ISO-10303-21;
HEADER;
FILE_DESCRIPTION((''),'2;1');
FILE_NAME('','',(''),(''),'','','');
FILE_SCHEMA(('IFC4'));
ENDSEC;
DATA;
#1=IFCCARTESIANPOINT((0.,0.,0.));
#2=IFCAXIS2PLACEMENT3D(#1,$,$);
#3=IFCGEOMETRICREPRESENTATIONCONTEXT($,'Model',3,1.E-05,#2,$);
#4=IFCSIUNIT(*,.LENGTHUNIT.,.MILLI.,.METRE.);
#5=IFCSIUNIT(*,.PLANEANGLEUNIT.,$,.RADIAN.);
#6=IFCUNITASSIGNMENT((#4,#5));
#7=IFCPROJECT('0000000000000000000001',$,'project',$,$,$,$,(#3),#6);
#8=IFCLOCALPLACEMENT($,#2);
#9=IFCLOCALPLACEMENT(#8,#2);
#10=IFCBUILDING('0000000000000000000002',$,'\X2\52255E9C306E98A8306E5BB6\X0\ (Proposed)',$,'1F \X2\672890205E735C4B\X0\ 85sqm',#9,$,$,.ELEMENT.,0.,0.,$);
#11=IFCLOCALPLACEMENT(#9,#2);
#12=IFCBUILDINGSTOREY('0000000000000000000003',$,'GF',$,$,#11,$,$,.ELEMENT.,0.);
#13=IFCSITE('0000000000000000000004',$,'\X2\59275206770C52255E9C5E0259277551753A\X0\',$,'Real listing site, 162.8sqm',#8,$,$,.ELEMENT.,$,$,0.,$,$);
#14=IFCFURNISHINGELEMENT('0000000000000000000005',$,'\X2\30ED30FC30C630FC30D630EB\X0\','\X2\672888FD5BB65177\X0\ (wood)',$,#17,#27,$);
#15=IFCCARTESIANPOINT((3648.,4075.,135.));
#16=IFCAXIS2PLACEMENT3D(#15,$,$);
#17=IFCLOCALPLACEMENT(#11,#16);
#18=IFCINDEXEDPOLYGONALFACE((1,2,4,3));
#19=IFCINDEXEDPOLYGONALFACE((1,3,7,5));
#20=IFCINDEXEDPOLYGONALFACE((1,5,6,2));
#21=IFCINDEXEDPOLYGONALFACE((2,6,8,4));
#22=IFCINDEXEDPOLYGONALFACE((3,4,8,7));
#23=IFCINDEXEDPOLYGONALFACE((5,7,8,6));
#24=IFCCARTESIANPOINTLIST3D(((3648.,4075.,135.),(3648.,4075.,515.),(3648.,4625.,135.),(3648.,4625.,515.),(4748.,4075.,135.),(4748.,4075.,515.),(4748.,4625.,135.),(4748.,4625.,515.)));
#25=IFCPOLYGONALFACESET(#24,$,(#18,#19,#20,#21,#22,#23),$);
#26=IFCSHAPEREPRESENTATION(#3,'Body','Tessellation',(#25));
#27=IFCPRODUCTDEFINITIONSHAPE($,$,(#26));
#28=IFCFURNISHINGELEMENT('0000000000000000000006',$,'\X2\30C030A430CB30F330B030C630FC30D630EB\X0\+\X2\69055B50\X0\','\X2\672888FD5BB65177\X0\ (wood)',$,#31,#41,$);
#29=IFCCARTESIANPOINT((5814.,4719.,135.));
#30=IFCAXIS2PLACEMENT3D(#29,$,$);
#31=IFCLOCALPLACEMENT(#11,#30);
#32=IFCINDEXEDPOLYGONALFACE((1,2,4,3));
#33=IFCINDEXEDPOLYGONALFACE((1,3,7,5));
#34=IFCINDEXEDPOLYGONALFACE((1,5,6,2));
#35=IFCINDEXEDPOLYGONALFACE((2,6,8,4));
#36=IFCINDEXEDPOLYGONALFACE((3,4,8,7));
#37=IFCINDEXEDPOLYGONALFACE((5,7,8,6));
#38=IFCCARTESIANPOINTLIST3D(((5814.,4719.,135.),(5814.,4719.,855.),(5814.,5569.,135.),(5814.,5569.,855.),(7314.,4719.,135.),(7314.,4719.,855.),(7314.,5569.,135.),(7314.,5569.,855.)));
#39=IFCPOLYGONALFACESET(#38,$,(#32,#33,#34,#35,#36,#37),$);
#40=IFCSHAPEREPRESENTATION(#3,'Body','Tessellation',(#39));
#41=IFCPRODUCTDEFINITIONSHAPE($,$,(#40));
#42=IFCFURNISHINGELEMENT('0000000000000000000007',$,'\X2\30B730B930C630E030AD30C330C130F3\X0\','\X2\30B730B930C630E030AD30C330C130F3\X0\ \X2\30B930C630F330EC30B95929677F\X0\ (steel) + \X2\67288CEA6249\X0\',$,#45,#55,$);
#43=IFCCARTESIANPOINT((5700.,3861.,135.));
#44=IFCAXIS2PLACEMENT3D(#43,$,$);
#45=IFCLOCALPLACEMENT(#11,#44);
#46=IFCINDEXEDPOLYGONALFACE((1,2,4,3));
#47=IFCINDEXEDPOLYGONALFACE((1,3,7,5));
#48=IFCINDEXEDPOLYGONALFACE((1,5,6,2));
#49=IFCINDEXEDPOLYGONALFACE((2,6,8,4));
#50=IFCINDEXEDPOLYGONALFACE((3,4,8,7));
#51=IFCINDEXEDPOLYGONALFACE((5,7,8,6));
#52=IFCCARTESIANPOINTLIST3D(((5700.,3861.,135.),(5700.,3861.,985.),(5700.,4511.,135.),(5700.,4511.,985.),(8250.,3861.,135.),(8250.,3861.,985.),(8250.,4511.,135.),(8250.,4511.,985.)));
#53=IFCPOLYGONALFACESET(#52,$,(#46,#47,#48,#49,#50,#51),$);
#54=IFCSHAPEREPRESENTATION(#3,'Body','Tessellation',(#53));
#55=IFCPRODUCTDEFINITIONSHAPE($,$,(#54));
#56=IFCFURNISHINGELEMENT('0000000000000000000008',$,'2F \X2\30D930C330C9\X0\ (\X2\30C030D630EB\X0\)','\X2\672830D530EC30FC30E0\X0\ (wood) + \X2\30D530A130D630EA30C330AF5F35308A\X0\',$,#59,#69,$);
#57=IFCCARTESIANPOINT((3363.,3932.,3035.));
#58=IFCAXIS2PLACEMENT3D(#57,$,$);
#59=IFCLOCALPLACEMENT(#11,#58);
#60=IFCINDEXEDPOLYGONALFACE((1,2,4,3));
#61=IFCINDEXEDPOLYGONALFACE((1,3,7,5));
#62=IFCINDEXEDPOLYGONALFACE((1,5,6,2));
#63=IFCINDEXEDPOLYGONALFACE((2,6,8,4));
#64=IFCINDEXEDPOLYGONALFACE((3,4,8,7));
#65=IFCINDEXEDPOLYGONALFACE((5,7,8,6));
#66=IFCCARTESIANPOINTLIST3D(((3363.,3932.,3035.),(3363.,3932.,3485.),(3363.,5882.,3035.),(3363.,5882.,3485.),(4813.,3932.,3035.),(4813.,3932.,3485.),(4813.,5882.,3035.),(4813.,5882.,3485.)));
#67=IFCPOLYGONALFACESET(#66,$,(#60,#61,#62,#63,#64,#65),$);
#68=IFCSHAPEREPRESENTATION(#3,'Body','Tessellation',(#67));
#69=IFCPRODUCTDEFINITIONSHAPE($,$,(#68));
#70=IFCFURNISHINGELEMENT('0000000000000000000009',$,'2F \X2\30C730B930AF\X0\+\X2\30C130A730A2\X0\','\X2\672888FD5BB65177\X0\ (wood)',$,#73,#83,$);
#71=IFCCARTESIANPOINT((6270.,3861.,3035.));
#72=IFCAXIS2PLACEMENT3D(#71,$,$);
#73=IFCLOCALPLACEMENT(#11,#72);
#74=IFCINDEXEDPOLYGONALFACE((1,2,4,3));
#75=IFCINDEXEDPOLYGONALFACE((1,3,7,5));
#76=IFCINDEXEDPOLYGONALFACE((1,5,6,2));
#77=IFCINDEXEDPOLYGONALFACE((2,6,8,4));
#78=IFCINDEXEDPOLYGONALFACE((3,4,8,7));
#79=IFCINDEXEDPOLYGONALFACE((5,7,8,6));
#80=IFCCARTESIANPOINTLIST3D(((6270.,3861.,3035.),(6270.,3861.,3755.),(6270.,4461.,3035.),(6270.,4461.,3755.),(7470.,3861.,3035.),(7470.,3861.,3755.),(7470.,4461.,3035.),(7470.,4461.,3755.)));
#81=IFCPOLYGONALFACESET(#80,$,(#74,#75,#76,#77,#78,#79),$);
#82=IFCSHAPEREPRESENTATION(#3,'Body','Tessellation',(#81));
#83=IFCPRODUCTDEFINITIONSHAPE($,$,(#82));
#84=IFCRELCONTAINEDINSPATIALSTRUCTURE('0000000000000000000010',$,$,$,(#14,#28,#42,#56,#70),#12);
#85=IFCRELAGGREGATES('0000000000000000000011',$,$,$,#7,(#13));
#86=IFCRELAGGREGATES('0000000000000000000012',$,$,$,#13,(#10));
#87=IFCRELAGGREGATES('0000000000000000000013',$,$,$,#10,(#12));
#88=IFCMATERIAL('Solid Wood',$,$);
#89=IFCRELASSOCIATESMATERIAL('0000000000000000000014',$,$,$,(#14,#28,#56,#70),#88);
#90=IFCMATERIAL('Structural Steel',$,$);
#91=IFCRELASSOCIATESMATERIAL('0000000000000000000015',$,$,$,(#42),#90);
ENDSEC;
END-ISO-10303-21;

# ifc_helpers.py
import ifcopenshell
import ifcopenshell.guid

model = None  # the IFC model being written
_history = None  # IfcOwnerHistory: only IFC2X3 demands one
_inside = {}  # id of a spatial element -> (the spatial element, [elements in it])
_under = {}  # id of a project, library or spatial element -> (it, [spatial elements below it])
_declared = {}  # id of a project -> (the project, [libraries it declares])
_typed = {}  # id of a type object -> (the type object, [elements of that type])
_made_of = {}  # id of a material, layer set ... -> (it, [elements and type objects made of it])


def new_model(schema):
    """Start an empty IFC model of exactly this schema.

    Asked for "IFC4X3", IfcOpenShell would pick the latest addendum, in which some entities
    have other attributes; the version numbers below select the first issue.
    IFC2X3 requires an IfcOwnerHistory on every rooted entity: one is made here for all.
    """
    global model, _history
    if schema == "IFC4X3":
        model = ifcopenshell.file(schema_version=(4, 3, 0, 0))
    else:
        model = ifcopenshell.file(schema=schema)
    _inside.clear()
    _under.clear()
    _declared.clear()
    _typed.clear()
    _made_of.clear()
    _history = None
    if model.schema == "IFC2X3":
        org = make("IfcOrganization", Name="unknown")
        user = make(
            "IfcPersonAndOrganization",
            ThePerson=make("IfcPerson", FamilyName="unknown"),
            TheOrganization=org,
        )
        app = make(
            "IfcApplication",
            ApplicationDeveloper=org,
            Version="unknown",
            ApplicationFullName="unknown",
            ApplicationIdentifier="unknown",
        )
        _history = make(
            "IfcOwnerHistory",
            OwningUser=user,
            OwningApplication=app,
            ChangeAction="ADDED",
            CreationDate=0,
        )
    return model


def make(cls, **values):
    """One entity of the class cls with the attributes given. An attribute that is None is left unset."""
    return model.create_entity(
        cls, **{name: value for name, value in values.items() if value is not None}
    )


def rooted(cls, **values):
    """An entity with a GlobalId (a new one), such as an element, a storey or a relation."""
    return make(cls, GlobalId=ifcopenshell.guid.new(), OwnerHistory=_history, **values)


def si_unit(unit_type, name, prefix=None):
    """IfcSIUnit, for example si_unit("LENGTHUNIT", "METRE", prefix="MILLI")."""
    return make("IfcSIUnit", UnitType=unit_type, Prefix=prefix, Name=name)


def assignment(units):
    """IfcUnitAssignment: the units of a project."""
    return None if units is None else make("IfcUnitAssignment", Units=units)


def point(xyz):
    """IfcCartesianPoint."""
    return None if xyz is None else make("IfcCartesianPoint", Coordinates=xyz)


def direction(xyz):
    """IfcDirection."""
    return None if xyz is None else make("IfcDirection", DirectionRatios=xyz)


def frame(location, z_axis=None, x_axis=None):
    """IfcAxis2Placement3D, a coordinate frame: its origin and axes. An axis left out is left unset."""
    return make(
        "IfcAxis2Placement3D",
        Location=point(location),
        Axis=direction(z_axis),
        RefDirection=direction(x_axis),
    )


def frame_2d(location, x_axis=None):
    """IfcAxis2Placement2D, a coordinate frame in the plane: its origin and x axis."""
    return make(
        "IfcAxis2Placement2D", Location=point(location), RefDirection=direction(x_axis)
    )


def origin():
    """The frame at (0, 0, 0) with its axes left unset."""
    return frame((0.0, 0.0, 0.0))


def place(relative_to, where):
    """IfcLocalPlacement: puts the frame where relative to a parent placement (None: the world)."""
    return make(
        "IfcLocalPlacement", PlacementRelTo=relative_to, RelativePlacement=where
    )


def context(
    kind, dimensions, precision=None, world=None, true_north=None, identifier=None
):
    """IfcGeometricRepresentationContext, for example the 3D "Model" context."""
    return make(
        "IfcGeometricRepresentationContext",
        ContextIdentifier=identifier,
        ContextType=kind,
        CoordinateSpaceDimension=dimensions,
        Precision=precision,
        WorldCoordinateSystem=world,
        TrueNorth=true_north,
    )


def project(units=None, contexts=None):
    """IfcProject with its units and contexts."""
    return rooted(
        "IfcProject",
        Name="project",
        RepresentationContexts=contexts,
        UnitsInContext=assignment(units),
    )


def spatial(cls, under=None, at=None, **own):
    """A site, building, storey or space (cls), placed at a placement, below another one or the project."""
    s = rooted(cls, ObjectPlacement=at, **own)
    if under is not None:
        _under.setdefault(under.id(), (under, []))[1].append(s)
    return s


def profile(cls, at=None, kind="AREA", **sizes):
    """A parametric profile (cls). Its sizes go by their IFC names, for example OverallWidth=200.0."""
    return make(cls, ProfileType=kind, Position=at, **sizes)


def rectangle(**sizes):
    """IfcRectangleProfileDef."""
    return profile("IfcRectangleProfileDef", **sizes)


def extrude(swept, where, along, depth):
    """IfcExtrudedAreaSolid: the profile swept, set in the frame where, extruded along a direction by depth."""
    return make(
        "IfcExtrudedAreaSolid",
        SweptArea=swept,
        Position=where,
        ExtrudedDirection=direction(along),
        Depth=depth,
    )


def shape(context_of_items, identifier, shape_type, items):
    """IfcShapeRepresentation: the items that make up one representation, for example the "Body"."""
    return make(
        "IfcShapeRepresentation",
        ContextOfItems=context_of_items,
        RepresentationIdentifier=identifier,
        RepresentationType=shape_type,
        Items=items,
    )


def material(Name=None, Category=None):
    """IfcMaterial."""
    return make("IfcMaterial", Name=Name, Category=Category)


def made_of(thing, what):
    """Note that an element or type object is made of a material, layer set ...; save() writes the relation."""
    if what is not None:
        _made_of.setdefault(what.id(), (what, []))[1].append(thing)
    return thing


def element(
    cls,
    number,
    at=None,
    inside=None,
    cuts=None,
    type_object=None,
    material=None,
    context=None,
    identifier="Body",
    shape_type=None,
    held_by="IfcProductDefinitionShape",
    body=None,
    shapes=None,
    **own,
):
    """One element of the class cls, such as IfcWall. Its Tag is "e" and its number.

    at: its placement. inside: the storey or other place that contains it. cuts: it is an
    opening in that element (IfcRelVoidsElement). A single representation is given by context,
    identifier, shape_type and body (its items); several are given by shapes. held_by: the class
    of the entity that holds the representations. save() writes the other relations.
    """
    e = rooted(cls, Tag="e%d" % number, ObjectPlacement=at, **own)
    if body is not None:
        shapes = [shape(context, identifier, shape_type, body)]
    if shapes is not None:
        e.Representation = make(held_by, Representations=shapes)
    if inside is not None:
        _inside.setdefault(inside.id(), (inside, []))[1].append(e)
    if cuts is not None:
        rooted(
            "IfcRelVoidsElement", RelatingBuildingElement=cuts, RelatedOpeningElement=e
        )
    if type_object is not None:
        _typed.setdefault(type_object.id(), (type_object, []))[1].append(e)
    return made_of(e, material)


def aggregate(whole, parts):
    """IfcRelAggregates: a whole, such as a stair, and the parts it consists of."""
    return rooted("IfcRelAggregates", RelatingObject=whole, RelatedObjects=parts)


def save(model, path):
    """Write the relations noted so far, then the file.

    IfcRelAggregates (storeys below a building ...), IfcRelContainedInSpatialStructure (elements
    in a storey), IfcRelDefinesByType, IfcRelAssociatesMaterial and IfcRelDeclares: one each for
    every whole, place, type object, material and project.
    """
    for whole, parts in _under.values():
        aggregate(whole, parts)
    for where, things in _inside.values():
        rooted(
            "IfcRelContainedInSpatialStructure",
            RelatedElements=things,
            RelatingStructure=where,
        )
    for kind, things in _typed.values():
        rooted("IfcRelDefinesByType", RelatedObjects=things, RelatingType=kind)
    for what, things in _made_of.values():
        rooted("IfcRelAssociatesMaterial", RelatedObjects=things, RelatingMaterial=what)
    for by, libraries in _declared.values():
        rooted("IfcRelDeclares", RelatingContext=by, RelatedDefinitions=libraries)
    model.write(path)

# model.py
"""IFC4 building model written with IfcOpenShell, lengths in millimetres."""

from ifc_helpers import new_model, si_unit, frame, frame_2d, origin, place, context, project, spatial, rectangle, extrude, material, element, save


model = new_model("IFC4")

# Units and contexts
model_context = context("Model", 3, precision=1e-05, world=origin())
ifc_project = project(units=[si_unit("LENGTHUNIT", "METRE", prefix="MILLI"), si_unit("PLANEANGLEUNIT", "RADIAN")], contexts=[model_context])

# Site, building, storey
site_placement = place(None, origin())
site = spatial("IfcSite", under=ifc_project, at=site_placement, Name="大分県別府市大畑町", ObjectType="Real listing site, 162.8sqm", CompositionType="ELEMENT", RefElevation=0.0)
building_placement = place(site_placement, origin())
building = spatial("IfcBuilding", under=site, at=building_placement, Name="別府の風の家 (Proposed)", ObjectType="1F 木造平屋 85sqm", CompositionType="ELEMENT", ElevationOfRefHeight=0.0, ElevationOfTerrain=0.0)
storey_placement = place(building_placement, origin())
storey = spatial("IfcBuildingStorey", under=building, at=storey_placement, Name="GF", CompositionType="ELEMENT", Elevation=0.0)

# Shared definitions
ifc_material_1 = material(Name="Solid Wood")

# Shared definitions
ifc_material_2 = material(Name="Structural Steel")

# Furnishing elements
furnishing_1_placement = place(storey_placement, frame((3648.0, 4075.0, 135.0)))
element("IfcFurnishingElement", 1, at=furnishing_1_placement, inside=storey, material=ifc_material_1, Name="ローテーブル", Description="木製家具 (wood)", context=model_context, shape_type="SweptSolid", body=[
    extrude(rectangle(XDim=1100.0, YDim=550.0, at=frame_2d((550.0, 275.0))), frame((3648.0, 4075.0, 135.0)), (0.0, 0.0, 1.0), 380.0),
])
furnishing_2_placement = place(storey_placement, frame((5814.0, 4719.0, 135.0)))
element("IfcFurnishingElement", 2, at=furnishing_2_placement, inside=storey, material=ifc_material_1, Name="ダイニングテーブル+椅子", Description="木製家具 (wood)", context=model_context, shape_type="SweptSolid", body=[
    extrude(rectangle(XDim=1500.0, YDim=850.0, at=frame_2d((750.0, 425.0))), frame((5814.0, 4719.0, 135.0)), (0.0, 0.0, 1.0), 720.0),
])
furnishing_3_placement = place(storey_placement, frame((5700.0, 3861.0, 135.0)))
element("IfcFurnishingElement", 3, at=furnishing_3_placement, inside=storey, material=ifc_material_2, Name="システムキッチン", Description="システムキッチン ステンレス天板 (steel) + 木質扉", context=model_context, shape_type="SweptSolid", body=[
    extrude(rectangle(XDim=2550.0, YDim=650.0, at=frame_2d((1275.0, 325.0))), frame((5700.0, 3861.0, 135.0)), (0.0, 0.0, 1.0), 850.0),
])
furnishing_4_placement = place(storey_placement, frame((3363.0, 3932.0, 3035.0)))
element("IfcFurnishingElement", 4, at=furnishing_4_placement, inside=storey, material=ifc_material_1, Name="2F ベッド (ダブル)", Description="木フレーム (wood) + ファブリック張り", context=model_context, shape_type="SweptSolid", body=[
    extrude(rectangle(XDim=1450.0, YDim=1950.0, at=frame_2d((725.0, 975.0))), frame((3363.0, 3932.0, 3035.0)), (0.0, 0.0, 1.0), 450.0),
])
furnishing_5_placement = place(storey_placement, frame((6270.0, 3861.0, 3035.0)))
element("IfcFurnishingElement", 5, at=furnishing_5_placement, inside=storey, material=ifc_material_1, Name="2F デスク+チェア", Description="木製家具 (wood)", context=model_context, shape_type="SweptSolid", body=[
    extrude(rectangle(XDim=1200.0, YDim=600.0, at=frame_2d((600.0, 300.0))), frame((6270.0, 3861.0, 3035.0)), (0.0, 0.0, 1.0), 720.0),
])

save(model, "model.ifc")
